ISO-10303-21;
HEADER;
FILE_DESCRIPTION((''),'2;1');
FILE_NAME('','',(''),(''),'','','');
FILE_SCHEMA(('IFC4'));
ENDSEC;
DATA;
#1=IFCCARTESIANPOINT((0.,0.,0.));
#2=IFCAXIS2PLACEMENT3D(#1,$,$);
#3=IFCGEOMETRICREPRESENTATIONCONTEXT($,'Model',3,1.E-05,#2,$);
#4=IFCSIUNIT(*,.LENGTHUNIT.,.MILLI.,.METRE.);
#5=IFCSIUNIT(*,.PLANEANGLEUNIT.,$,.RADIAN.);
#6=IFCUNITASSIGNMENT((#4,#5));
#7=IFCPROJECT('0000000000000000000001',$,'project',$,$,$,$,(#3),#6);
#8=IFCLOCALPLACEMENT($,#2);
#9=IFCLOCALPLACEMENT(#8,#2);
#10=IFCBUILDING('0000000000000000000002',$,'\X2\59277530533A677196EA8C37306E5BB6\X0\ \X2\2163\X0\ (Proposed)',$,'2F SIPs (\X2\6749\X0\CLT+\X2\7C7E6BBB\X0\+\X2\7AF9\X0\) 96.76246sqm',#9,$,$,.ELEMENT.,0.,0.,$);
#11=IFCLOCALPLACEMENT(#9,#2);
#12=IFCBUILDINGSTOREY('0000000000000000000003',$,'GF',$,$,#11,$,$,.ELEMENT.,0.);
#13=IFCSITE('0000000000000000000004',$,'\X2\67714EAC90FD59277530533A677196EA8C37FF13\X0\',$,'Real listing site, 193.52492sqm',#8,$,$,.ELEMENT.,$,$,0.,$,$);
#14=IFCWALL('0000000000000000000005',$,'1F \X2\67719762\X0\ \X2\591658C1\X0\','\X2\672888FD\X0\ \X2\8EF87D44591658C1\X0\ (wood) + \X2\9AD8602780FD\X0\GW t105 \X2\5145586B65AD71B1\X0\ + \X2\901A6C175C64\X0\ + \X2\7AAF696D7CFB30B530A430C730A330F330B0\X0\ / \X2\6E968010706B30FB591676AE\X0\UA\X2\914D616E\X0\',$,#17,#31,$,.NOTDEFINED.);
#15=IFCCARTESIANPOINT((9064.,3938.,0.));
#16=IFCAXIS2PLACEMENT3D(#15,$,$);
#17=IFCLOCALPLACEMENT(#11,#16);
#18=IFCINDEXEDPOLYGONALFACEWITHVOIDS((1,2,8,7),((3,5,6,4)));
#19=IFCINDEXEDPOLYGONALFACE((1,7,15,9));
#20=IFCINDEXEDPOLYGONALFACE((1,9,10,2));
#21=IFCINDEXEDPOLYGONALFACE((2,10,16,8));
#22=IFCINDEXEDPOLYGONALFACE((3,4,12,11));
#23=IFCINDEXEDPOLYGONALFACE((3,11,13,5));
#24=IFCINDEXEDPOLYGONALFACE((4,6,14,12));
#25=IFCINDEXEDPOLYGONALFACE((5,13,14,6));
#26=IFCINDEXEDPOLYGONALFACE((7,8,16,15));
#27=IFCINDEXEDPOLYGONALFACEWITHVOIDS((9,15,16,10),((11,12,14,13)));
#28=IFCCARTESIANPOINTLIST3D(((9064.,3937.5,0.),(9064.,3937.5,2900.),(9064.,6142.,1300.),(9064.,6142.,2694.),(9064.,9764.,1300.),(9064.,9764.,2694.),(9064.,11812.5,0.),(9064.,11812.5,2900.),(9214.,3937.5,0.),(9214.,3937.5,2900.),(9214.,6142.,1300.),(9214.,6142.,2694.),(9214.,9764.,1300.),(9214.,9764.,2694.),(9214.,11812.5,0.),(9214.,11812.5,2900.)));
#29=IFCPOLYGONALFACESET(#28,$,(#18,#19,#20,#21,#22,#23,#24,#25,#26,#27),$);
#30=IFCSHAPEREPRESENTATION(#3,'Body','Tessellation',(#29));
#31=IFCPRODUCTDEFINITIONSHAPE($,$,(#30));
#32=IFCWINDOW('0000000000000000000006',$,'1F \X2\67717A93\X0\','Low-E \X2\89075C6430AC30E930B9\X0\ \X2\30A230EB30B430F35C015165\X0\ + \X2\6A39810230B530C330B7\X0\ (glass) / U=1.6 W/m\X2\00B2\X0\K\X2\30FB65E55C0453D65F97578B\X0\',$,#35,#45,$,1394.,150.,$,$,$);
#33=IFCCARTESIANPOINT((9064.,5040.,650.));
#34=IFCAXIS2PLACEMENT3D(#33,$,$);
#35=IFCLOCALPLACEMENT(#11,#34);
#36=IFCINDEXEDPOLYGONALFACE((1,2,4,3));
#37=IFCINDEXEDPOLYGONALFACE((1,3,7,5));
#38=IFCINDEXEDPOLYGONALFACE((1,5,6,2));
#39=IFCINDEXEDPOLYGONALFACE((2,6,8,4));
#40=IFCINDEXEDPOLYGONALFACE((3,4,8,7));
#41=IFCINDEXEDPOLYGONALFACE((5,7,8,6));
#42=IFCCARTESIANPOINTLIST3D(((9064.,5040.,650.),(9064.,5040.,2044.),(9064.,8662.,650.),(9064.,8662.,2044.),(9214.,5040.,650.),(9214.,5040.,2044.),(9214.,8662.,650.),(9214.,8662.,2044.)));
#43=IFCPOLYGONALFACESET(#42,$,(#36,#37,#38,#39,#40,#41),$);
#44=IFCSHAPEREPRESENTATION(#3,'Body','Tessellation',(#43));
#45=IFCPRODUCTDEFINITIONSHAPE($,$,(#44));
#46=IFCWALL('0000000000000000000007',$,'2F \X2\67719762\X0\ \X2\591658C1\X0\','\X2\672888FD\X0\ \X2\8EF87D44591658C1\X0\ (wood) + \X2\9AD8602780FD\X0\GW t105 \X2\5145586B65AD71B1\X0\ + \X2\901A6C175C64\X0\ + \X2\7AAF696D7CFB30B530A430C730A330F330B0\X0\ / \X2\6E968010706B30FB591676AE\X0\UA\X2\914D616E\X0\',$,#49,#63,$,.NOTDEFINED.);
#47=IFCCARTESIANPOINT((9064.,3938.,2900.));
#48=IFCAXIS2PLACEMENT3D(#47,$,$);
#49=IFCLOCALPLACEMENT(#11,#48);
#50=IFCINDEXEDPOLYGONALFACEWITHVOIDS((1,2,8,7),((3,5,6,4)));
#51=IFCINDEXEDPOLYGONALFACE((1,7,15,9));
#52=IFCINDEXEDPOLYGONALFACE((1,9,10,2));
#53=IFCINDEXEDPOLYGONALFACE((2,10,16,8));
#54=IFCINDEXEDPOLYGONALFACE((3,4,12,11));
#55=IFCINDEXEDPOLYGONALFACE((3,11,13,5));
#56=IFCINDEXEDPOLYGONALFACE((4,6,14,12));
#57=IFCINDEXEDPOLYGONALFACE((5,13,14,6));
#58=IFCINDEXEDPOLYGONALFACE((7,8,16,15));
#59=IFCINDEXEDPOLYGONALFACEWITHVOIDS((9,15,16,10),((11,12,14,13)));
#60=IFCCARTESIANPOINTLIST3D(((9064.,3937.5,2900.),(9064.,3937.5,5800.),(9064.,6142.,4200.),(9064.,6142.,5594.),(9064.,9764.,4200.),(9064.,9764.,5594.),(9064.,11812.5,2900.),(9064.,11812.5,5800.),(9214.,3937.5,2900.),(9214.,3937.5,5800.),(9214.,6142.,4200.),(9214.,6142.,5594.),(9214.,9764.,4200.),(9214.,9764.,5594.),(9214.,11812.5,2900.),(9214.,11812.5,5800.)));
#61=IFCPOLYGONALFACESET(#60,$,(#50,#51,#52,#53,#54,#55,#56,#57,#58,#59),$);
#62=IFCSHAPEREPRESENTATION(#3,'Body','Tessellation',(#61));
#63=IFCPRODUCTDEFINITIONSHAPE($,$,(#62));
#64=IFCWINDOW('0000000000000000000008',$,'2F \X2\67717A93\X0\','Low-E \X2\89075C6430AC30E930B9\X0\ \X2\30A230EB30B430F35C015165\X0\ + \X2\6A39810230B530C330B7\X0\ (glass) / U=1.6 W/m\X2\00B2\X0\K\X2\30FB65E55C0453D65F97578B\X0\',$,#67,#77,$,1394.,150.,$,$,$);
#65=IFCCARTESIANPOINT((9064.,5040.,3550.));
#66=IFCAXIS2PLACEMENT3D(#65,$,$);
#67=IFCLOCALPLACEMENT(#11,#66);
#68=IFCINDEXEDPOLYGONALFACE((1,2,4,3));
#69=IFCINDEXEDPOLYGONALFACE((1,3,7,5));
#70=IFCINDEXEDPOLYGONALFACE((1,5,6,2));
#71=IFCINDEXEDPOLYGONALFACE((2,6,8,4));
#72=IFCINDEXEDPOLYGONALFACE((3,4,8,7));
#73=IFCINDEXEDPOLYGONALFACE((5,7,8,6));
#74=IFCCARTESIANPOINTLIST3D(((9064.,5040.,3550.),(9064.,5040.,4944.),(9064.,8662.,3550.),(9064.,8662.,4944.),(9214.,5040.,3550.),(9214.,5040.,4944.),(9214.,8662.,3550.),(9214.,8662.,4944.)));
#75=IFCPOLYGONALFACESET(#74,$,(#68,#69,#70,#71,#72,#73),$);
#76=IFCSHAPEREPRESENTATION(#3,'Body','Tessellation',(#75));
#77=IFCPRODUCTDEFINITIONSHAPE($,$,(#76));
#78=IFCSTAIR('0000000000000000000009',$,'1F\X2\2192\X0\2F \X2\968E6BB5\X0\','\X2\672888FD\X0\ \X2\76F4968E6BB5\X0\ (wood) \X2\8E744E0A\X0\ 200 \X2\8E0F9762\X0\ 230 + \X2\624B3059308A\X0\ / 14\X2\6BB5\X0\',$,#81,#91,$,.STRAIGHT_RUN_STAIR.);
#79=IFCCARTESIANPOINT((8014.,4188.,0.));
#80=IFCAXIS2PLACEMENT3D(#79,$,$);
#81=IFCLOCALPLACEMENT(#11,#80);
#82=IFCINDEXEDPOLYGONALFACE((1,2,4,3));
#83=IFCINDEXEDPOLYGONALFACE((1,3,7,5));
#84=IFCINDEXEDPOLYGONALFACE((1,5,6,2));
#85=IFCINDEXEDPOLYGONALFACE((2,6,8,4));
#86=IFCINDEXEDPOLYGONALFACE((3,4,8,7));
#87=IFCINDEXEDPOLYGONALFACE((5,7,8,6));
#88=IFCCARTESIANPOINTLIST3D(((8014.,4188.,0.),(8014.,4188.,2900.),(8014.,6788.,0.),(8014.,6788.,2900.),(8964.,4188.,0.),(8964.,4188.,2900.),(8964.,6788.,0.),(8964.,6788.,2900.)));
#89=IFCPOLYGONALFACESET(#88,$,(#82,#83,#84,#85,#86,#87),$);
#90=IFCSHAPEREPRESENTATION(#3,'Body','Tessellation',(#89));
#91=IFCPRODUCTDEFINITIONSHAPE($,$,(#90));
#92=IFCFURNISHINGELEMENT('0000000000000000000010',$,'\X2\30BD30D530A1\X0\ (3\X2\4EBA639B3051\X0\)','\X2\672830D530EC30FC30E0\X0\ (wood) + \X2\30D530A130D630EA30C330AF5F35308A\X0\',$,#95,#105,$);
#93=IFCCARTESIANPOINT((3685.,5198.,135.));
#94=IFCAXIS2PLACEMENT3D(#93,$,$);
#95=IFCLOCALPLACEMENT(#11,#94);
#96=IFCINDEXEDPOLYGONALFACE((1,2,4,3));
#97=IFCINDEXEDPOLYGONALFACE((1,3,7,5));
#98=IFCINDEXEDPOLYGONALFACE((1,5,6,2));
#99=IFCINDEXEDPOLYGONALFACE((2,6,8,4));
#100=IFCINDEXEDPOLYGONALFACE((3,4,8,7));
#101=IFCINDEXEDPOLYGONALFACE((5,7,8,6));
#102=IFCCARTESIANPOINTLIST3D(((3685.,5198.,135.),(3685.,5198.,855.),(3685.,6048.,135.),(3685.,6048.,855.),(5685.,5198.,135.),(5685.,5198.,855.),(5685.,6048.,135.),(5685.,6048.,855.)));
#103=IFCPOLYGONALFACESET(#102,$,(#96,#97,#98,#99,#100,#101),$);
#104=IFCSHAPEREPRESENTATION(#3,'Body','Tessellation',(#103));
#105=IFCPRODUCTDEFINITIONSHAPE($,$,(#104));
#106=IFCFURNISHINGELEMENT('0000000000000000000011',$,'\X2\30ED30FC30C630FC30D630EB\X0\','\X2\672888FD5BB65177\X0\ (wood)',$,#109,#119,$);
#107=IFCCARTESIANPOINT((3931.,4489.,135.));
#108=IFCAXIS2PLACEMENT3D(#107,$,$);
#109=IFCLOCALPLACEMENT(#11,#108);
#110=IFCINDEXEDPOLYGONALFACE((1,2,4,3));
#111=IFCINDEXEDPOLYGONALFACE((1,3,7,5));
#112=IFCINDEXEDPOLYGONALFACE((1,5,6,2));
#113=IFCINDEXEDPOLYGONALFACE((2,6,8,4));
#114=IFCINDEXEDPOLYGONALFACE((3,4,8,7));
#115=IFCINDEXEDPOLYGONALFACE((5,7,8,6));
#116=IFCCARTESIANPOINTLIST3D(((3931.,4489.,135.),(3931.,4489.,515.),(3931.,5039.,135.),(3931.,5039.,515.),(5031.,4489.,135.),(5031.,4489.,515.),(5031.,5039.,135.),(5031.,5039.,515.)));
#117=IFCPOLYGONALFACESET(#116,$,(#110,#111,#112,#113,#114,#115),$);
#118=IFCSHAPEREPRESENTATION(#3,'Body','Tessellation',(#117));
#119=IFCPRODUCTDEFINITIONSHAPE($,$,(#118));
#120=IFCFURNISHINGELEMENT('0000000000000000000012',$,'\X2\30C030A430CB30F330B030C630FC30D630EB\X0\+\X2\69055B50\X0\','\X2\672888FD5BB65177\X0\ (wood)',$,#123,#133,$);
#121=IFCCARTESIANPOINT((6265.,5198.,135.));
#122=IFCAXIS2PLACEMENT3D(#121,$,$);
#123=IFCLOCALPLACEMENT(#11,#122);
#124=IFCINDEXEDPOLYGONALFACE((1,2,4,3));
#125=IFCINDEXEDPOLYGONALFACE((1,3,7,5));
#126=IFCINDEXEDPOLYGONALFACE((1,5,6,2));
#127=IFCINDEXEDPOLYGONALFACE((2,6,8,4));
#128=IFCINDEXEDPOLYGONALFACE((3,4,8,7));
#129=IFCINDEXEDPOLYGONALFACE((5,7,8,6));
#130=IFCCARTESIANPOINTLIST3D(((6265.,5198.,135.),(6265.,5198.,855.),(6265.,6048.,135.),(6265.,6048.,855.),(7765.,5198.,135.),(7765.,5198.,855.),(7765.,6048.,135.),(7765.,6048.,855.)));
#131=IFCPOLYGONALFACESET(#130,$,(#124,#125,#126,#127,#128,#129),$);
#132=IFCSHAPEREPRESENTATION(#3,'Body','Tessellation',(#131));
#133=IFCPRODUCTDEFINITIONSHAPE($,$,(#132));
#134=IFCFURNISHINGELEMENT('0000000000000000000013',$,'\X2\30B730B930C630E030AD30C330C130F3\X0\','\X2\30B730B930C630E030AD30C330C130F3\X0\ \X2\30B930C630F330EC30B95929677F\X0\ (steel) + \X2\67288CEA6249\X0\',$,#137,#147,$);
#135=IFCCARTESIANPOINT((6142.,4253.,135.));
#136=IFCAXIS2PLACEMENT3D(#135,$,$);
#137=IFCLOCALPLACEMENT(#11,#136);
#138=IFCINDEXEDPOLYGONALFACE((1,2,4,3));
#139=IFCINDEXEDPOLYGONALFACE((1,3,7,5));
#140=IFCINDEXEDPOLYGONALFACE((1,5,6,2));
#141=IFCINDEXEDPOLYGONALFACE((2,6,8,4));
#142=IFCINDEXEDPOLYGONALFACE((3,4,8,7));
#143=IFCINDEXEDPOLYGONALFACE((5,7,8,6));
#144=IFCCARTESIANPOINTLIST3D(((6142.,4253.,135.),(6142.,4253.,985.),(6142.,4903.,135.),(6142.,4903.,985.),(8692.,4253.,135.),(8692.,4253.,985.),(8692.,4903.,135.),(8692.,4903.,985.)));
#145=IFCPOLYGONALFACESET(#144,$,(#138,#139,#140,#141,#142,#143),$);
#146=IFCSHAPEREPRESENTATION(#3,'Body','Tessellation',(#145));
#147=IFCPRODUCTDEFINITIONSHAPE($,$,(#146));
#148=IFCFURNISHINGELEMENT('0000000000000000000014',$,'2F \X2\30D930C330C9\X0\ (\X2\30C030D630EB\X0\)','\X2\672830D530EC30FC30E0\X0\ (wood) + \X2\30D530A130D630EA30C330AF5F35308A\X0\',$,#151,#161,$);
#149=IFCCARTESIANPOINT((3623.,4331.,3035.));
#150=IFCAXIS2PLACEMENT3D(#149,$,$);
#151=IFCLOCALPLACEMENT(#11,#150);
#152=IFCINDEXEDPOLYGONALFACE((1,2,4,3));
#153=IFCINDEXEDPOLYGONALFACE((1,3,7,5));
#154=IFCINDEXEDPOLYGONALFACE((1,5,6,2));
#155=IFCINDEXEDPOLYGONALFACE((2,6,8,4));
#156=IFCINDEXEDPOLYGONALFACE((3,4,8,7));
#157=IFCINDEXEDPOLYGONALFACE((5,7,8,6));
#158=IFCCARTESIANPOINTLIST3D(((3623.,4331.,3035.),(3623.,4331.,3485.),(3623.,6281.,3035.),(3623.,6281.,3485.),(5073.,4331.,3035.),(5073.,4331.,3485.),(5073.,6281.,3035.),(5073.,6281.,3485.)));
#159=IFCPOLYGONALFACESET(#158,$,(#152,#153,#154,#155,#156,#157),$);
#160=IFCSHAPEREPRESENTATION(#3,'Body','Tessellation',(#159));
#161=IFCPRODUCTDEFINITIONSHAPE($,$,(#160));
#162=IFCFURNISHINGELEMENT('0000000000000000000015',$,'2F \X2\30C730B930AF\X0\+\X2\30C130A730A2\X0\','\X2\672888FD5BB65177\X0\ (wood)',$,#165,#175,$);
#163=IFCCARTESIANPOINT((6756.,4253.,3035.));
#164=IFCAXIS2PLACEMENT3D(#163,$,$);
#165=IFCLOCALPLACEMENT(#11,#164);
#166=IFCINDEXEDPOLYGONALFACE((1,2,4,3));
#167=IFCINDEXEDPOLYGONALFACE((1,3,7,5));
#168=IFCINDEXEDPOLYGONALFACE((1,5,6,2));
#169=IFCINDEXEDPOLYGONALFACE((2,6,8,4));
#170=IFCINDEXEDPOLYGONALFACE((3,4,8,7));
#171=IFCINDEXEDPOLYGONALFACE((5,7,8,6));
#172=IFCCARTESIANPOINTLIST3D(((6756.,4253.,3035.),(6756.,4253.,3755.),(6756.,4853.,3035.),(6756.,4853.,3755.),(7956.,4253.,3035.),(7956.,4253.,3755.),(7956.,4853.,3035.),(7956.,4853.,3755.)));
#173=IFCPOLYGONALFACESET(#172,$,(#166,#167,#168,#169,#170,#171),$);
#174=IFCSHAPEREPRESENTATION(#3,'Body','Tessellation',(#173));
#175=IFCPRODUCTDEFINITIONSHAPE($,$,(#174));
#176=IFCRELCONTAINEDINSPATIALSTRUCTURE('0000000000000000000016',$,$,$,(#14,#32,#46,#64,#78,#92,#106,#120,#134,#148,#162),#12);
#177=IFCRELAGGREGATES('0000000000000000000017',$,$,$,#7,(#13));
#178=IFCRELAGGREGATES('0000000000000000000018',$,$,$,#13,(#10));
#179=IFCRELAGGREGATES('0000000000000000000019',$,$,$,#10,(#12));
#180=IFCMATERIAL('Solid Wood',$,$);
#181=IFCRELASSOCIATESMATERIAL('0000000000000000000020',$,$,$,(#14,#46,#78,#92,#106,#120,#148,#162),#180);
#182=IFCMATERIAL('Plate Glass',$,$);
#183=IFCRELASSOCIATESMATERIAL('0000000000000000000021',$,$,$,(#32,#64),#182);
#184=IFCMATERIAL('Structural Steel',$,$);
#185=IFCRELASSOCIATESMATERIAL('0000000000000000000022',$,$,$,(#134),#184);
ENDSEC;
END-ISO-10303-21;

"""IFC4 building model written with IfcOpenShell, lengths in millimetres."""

from ifc_helpers import new_model, si_unit, frame, frame_2d, origin, place, context, project, spatial, rectangle, extrude, material, element, fill, save


model = new_model("IFC4")

# Units and contexts
model_context = context("Model", 3, precision=1e-05, world=origin())
ifc_project = project(units=[si_unit("LENGTHUNIT", "METRE", prefix="MILLI"), si_unit("PLANEANGLEUNIT", "RADIAN")], contexts=[model_context])

# Site, building, storey
site_placement = place(None, origin())
site = spatial("IfcSite", under=ifc_project, at=site_placement, Name="東京都大田区東雪谷３", ObjectType="Real listing site, 193.52492sqm", CompositionType="ELEMENT", RefElevation=0.0)
building_placement = place(site_placement, origin())
building = spatial("IfcBuilding", under=site, at=building_placement, Name="大田区東雪谷の家 Ⅳ (Proposed)", ObjectType="2F SIPs (杉CLT+籾殻+竹) 96.76246sqm", CompositionType="ELEMENT", ElevationOfRefHeight=0.0, ElevationOfTerrain=0.0)
storey_placement = place(building_placement, origin())
storey = spatial("IfcBuildingStorey", under=building, at=storey_placement, Name="GF", CompositionType="ELEMENT", Elevation=0.0)

# Wall, opening, window
ifc_material_1 = material(Name="Solid Wood")
wall_1_placement = place(storey_placement, frame((9064.0, 3938.0, 0.0)))
wall_1 = element("IfcWall", 1, at=wall_1_placement, inside=storey, material=ifc_material_1, Name="1F 東面 外壁", Description="木製 軸組外壁 (wood) + 高性能GW t105 充填断熱 + 通気層 + 窯業系サイディング / 準耐火・外皮UA配慮", PredefinedType="NOTDEFINED", context=model_context, shape_type="SweptSolid", body=[
    extrude(rectangle(XDim=150.0, YDim=7875.0, at=frame_2d((75.0, 3937.0))), frame((9064.0, 3938.0, 0.0)), (0.0, 0.0, 1.0), 2900.0),
])
opening_1_placement = place(storey_placement, frame((9064.0, 5040.0, 650.0)))
opening_1 = element("IfcOpeningElement", 2, at=opening_1_placement, cuts=wall_1, PredefinedType="NOTDEFINED", context=model_context, shape_type="SweptSolid", body=[
    extrude(rectangle(XDim=150.0, YDim=3622.0, at=frame_2d((75.0, 1811.0))), frame((9064.0, 5040.0, 650.0)), (0.0, 0.0, 1.0), 1394.0),
])
ifc_material_2 = material(Name="Plate Glass")
window_1_placement = place(storey_placement, frame((9064.0, 5040.0, 650.0)))
window_1 = element("IfcWindow", 3, at=window_1_placement, inside=storey, material=ifc_material_2, Name="1F 東窓", Description="Low-E 複層ガラス アルゴン封入 + 樹脂サッシ (glass) / U=1.6 W/m²K・日射取得型", OverallHeight=1394.0, OverallWidth=150.0, context=model_context, shape_type="SweptSolid", body=[
    extrude(rectangle(XDim=150.0, YDim=3622.0, at=frame_2d((75.0, 1811.0))), frame((9064.0, 5040.0, 650.0)), (0.0, 0.0, 1.0), 1394.0),
])
fill(opening_1, window_1)

# Wall, opening, window
wall_2_placement = place(storey_placement, frame((9064.0, 3938.0, 2900.0)))
wall_2 = element("IfcWall", 4, at=wall_2_placement, inside=storey, material=ifc_material_1, Name="2F 東面 外壁", Description="木製 軸組外壁 (wood) + 高性能GW t105 充填断熱 + 通気層 + 窯業系サイディング / 準耐火・外皮UA配慮", PredefinedType="NOTDEFINED", context=model_context, shape_type="SweptSolid", body=[
    extrude(rectangle(XDim=150.0, YDim=7875.0, at=frame_2d((75.0, 3937.0))), frame((9064.0, 3938.0, 2900.0)), (0.0, 0.0, 1.0), 2900.0),
])
opening_2_placement = place(storey_placement, frame((9064.0, 5040.0, 3550.0)))
opening_2 = element("IfcOpeningElement", 5, at=opening_2_placement, cuts=wall_2, PredefinedType="NOTDEFINED", context=model_context, shape_type="SweptSolid", body=[
    extrude(rectangle(XDim=150.0, YDim=3622.0, at=frame_2d((75.0, 1811.0))), frame((9064.0, 5040.0, 3550.0)), (0.0, 0.0, 1.0), 1394.0),
])
window_2_placement = place(storey_placement, frame((9064.0, 5040.0, 3550.0)))
window_2 = element("IfcWindow", 6, at=window_2_placement, inside=storey, material=ifc_material_2, Name="2F 東窓", Description="Low-E 複層ガラス アルゴン封入 + 樹脂サッシ (glass) / U=1.6 W/m²K・日射取得型", OverallHeight=1394.0, OverallWidth=150.0, context=model_context, shape_type="SweptSolid", body=[
    extrude(rectangle(XDim=150.0, YDim=3622.0, at=frame_2d((75.0, 1811.0))), frame((9064.0, 5040.0, 3550.0)), (0.0, 0.0, 1.0), 1394.0),
])
fill(opening_2, window_2)

# Stair
stair_placement = place(storey_placement, frame((8014.0, 4188.0, 0.0)))
element("IfcStair", 7, at=stair_placement, inside=storey, material=ifc_material_1, Name="1F→2F 階段", Description="木製 直階段 (wood) 蹴上 200 踏面 230 + 手すり / 14段", PredefinedType="STRAIGHT_RUN_STAIR", context=model_context, shape_type="SweptSolid", body=[
    extrude(rectangle(XDim=950.0, YDim=2600.0, at=frame_2d((475.0, 1300.0))), frame((8014.0, 4188.0, 0.0)), (0.0, 0.0, 1.0), 2900.0),
])

# Furnishing elements
furnishing_1_placement = place(storey_placement, frame((3685.0, 5198.0, 135.0)))
element("IfcFurnishingElement", 8, at=furnishing_1_placement, inside=storey, material=ifc_material_1, Name="ソファ (3人掛け)", Description="木フレーム (wood) + ファブリック張り", context=model_context, shape_type="SweptSolid", body=[
    extrude(rectangle(XDim=2000.0, YDim=850.0, at=frame_2d((1000.0, 425.0))), frame((3685.0, 5198.0, 135.0)), (0.0, 0.0, 1.0), 720.0),
])
furnishing_2_placement = place(storey_placement, frame((3931.0, 4489.0, 135.0)))
element("IfcFurnishingElement", 9, at=furnishing_2_placement, inside=storey, material=ifc_material_1, Name="ローテーブル", Description="木製家具 (wood)", context=model_context, shape_type="SweptSolid", body=[
    extrude(rectangle(XDim=1100.0, YDim=550.0, at=frame_2d((550.0, 275.0))), frame((3931.0, 4489.0, 135.0)), (0.0, 0.0, 1.0), 380.0),
])
furnishing_3_placement = place(storey_placement, frame((6265.0, 5198.0, 135.0)))
element("IfcFurnishingElement", 10, at=furnishing_3_placement, inside=storey, material=ifc_material_1, Name="ダイニングテーブル+椅子", Description="木製家具 (wood)", context=model_context, shape_type="SweptSolid", body=[
    extrude(rectangle(XDim=1500.0, YDim=850.0, at=frame_2d((750.0, 425.0))), frame((6265.0, 5198.0, 135.0)), (0.0, 0.0, 1.0), 720.0),
])
ifc_material_3 = material(Name="Structural Steel")
furnishing_4_placement = place(storey_placement, frame((6142.0, 4253.0, 135.0)))
element("IfcFurnishingElement", 11, at=furnishing_4_placement, inside=storey, material=ifc_material_3, Name="システムキッチン", Description="システムキッチン ステンレス天板 (steel) + 木質扉", context=model_context, shape_type="SweptSolid", body=[
    extrude(rectangle(XDim=2550.0, YDim=650.0, at=frame_2d((1275.0, 325.0))), frame((6142.0, 4253.0, 135.0)), (0.0, 0.0, 1.0), 850.0),
])
furnishing_5_placement = place(storey_placement, frame((3623.0, 4331.0, 3035.0)))
element("IfcFurnishingElement", 12, at=furnishing_5_placement, inside=storey, material=ifc_material_1, Name="2F ベッド (ダブル)", Description="木フレーム (wood) + ファブリック張り", context=model_context, shape_type="SweptSolid", body=[
    extrude(rectangle(XDim=1450.0, YDim=1950.0, at=frame_2d((725.0, 975.0))), frame((3623.0, 4331.0, 3035.0)), (0.0, 0.0, 1.0), 450.0),
])
furnishing_6_placement = place(storey_placement, frame((6756.0, 4253.0, 3035.0)))
element("IfcFurnishingElement", 13, at=furnishing_6_placement, inside=storey, material=ifc_material_1, Name="2F デスク+チェア", Description="木製家具 (wood)", context=model_context, shape_type="SweptSolid", body=[
    extrude(rectangle(XDim=1200.0, YDim=600.0, at=frame_2d((600.0, 300.0))), frame((6756.0, 4253.0, 3035.0)), (0.0, 0.0, 1.0), 720.0),
])

save(model, "model.ifc")
